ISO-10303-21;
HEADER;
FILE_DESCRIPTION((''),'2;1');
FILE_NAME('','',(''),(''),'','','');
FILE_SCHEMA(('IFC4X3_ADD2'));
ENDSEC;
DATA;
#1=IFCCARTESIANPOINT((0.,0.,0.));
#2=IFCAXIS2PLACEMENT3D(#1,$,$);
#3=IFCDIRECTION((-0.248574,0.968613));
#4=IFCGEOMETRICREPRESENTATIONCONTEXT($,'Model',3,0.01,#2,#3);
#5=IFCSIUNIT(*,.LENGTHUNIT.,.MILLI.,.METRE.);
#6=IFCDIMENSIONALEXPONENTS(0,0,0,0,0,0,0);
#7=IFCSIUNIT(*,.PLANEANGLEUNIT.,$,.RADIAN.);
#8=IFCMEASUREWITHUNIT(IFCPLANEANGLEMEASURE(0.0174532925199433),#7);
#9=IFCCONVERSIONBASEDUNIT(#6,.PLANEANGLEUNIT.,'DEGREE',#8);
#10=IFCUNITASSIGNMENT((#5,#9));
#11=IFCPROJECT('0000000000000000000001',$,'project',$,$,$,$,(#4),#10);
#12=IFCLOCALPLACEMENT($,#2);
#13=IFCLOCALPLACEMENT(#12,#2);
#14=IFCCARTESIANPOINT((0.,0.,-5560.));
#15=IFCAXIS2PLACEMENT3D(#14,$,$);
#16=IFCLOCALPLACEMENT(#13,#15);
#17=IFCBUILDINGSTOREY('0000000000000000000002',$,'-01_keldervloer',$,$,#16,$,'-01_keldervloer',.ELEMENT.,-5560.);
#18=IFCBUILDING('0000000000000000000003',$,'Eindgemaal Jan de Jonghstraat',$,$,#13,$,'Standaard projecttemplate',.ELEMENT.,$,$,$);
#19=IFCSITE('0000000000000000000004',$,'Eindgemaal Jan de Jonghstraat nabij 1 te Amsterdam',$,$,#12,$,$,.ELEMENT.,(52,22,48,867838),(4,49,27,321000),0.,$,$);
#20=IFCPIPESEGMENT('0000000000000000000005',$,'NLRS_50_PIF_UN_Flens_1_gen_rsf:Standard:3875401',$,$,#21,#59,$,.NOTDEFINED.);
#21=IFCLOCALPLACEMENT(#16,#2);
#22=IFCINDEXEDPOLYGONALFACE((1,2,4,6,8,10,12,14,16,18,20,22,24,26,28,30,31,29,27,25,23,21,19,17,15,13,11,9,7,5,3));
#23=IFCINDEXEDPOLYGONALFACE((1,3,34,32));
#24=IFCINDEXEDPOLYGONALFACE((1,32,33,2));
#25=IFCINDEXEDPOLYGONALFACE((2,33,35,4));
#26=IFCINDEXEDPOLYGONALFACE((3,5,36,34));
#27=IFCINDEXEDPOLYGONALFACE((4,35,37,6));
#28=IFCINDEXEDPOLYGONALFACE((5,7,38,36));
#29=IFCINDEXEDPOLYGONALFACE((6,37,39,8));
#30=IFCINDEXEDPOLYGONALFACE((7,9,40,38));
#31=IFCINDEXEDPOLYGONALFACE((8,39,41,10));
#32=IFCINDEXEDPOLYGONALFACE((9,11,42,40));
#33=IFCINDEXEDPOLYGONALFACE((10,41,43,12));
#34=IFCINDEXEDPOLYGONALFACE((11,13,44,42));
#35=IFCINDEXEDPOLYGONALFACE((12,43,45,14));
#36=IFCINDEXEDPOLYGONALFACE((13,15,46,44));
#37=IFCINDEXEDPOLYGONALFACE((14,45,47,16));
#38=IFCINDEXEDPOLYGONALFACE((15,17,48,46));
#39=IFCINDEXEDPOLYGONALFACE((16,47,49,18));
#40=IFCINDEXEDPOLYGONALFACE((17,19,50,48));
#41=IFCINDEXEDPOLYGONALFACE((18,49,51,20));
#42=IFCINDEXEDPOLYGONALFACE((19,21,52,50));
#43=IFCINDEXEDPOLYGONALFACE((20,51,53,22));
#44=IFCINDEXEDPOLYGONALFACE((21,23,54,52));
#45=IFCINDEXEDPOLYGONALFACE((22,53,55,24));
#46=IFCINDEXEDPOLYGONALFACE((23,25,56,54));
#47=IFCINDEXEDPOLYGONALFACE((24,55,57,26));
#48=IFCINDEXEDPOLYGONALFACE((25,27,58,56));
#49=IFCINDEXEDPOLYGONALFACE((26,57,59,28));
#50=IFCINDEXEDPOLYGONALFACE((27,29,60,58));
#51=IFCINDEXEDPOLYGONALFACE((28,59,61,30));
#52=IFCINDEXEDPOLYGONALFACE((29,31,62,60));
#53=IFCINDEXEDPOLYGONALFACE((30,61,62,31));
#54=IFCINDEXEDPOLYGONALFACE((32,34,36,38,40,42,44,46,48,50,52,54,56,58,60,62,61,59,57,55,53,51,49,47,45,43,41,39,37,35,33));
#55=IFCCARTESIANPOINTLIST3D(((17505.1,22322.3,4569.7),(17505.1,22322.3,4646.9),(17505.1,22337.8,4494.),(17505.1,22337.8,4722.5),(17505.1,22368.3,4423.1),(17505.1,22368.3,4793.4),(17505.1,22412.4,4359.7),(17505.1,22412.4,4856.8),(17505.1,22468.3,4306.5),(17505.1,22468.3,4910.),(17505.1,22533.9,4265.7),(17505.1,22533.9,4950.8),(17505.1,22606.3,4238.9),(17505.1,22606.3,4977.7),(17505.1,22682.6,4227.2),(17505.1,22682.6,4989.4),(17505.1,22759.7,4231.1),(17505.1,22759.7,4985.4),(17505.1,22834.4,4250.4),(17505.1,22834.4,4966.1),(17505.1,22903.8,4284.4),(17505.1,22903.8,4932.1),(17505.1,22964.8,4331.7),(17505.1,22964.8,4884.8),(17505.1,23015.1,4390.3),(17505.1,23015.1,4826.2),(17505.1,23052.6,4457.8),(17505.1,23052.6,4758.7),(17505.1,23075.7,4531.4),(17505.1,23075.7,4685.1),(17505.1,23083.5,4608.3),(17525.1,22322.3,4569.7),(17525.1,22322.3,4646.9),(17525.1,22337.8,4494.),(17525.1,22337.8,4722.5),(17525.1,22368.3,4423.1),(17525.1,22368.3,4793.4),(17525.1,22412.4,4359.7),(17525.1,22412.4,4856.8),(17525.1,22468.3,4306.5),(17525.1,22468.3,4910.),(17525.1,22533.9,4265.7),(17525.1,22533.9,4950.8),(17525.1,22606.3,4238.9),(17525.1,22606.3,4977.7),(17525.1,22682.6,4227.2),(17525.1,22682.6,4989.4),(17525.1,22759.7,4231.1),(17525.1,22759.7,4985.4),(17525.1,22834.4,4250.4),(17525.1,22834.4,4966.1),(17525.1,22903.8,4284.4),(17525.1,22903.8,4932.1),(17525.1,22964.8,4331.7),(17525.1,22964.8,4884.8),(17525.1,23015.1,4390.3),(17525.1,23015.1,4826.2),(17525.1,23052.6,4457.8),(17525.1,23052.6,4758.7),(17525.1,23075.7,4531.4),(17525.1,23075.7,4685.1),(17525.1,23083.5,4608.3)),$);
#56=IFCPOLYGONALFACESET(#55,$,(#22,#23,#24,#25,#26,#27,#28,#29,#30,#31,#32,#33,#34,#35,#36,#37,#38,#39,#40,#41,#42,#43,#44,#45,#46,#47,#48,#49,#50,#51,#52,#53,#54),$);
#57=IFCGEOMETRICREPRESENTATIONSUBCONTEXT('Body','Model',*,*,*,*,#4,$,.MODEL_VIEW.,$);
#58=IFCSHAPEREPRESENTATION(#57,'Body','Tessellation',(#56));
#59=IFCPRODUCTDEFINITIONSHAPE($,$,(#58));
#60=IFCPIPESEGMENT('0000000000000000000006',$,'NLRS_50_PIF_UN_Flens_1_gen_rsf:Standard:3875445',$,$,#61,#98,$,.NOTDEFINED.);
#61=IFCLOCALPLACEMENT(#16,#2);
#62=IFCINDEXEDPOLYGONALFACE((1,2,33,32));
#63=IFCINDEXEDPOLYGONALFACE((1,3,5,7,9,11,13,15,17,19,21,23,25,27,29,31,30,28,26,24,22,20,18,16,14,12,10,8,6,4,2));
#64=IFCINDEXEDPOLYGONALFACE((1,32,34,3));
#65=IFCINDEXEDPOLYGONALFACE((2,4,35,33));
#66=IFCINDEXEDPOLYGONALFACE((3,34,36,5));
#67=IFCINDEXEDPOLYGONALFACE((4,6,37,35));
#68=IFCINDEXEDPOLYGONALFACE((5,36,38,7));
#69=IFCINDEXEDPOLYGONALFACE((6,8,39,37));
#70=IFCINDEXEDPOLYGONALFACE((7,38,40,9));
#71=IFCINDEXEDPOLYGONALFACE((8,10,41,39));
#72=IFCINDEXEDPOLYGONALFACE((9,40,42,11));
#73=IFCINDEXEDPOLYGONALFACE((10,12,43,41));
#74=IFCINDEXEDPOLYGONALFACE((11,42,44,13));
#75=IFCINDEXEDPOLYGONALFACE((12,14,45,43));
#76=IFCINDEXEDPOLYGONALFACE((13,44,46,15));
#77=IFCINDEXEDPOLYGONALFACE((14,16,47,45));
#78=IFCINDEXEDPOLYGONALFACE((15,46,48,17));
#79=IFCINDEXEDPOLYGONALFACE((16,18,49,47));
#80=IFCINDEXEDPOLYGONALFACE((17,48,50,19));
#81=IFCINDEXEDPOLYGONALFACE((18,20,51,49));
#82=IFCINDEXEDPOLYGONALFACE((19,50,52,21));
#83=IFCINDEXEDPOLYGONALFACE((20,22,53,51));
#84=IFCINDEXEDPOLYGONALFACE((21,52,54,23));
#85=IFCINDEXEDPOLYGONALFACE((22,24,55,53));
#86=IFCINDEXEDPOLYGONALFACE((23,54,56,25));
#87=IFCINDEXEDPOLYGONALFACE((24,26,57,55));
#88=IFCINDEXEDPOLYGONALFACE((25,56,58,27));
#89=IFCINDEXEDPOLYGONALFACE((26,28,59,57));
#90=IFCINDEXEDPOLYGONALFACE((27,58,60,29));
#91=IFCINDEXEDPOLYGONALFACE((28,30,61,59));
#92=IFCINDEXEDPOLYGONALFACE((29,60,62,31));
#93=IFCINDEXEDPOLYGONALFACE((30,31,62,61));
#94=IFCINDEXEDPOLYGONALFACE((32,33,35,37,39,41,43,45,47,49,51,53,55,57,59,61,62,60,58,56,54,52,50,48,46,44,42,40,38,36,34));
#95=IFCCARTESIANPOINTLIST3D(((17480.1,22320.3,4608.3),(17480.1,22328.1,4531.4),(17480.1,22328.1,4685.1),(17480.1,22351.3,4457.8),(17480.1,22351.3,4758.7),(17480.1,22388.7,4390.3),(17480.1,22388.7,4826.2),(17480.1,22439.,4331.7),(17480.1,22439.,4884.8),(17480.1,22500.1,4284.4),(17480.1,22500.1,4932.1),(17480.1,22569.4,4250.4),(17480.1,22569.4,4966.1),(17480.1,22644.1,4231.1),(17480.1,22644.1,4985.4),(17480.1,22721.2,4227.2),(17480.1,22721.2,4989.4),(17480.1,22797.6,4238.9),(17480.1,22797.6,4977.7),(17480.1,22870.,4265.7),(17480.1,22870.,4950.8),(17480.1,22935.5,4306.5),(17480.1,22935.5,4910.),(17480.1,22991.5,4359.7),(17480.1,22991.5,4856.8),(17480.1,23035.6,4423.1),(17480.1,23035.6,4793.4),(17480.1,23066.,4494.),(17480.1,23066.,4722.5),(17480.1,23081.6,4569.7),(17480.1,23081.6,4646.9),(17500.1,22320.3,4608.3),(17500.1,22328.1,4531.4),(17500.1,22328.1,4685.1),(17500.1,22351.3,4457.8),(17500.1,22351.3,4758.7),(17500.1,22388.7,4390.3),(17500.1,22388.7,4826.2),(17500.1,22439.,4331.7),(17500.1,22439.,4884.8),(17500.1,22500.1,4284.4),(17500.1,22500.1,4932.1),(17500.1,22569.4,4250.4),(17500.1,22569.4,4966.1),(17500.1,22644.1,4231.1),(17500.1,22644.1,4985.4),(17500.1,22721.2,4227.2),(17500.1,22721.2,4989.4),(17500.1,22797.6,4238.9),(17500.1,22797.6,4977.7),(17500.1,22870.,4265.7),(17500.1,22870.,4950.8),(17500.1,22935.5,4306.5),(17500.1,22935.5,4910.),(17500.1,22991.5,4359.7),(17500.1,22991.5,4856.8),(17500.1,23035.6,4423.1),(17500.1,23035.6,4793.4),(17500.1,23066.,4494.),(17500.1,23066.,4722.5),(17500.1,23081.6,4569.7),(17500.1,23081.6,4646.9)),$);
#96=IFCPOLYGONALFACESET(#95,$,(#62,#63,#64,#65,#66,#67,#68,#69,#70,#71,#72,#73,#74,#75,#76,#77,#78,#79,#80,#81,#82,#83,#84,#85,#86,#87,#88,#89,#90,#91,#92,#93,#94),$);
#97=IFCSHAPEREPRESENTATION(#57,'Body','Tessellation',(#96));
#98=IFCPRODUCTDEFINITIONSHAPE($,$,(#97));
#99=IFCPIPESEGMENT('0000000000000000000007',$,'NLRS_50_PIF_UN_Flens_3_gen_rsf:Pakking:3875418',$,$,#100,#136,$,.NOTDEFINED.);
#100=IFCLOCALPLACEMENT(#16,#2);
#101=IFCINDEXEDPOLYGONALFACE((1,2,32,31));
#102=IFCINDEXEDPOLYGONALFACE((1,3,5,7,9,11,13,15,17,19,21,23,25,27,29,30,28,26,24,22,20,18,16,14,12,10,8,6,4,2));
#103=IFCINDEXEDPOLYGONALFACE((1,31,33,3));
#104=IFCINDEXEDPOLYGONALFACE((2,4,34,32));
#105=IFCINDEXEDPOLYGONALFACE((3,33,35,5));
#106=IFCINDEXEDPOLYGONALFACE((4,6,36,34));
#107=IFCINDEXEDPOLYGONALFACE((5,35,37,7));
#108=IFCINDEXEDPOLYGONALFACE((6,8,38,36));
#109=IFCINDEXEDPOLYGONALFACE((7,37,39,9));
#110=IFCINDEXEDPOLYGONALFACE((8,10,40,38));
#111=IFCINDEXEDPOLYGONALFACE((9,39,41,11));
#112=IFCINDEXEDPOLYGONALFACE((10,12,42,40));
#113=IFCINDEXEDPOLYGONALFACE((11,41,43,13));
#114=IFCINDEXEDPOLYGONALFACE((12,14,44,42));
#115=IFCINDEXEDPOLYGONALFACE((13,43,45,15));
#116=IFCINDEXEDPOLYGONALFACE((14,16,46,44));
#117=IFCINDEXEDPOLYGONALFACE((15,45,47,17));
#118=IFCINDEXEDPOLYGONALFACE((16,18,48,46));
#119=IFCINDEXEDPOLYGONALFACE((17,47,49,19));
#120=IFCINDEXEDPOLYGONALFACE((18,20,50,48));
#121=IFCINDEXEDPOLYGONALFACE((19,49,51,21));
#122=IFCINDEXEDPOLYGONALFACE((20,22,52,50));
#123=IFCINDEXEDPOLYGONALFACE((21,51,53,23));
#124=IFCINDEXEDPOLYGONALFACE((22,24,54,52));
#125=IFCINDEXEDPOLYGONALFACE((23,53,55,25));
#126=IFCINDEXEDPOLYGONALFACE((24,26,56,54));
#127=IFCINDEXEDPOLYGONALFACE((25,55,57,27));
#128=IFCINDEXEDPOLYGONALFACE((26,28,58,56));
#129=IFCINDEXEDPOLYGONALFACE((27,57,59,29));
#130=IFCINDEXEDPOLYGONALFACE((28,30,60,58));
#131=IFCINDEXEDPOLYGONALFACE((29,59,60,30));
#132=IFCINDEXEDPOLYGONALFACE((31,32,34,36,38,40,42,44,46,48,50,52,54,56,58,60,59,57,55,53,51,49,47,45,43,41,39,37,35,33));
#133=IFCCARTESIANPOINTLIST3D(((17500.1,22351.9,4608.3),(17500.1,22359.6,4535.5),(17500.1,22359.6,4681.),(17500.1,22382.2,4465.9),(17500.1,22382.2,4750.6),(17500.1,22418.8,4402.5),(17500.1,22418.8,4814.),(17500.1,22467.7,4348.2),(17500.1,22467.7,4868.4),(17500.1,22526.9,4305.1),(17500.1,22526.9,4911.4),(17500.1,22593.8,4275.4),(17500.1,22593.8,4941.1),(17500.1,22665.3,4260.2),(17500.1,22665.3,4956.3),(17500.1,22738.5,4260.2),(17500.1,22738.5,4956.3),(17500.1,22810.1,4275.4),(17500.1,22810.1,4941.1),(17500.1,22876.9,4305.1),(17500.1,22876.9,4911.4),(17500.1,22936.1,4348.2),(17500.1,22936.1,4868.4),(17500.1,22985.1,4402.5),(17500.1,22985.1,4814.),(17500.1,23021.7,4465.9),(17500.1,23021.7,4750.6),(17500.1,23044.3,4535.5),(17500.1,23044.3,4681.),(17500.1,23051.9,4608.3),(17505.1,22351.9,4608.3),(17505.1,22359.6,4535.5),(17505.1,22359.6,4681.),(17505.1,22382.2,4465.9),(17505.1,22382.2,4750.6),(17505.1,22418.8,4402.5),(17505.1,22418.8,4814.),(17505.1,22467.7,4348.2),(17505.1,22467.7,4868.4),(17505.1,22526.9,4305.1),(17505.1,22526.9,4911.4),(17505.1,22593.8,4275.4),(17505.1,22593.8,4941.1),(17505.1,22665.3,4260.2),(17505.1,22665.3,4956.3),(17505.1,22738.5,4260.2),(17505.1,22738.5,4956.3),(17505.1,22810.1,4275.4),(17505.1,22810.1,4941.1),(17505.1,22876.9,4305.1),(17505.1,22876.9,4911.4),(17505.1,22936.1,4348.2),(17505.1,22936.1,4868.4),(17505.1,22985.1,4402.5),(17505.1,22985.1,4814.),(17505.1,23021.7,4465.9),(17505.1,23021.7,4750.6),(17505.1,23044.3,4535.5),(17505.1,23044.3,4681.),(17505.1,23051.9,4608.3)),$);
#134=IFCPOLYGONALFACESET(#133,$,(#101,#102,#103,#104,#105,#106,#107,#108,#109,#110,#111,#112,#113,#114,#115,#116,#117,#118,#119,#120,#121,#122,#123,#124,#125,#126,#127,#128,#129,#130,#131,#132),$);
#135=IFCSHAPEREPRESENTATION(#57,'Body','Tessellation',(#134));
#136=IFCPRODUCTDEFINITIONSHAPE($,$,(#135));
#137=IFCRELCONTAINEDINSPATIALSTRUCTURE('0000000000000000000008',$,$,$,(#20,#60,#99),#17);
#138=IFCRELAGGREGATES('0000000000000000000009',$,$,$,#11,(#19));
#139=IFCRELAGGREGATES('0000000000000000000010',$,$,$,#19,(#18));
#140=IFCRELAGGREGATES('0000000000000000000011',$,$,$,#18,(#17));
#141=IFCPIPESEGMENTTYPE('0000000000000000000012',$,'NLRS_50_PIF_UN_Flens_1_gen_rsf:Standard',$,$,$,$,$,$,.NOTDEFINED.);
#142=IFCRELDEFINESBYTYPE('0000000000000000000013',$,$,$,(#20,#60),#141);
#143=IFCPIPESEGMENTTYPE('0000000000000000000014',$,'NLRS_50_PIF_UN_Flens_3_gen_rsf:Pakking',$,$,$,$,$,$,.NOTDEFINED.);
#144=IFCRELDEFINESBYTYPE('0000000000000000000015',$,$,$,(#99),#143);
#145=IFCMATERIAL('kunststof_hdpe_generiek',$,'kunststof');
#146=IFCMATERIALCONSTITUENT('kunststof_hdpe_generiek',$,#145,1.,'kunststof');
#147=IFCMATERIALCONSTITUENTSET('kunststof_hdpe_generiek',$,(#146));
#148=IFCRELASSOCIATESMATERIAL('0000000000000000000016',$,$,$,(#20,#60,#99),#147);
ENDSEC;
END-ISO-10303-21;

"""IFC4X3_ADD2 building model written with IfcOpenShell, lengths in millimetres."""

from ifc_helpers import new_model, entity, si_unit, converted_unit, direction, frame, frame_2d, origin, place, context, subcontext, project, spatial, circle, extrude, source, transform, mapped, material, constituent, constituent_set, type_object, type_shapes, element, save


model = new_model("IFC4X3_ADD2")

# Units and contexts
model_context = context("Model", 3, precision=0.01, world=origin(), true_north=direction((-0.248574, 0.968613)))
body_context = subcontext(model_context, "Body", "Model", "MODEL_VIEW")
ifc_project = project(units=[si_unit("LENGTHUNIT", "METRE", prefix="MILLI"), converted_unit("PLANEANGLEUNIT", "DEGREE", entity("IfcPlaneAngleMeasure", 0.0174532925199433), si_unit("PLANEANGLEUNIT", "RADIAN"), dimensions=[0, 0, 0, 0, 0, 0, 0])], contexts=[model_context])

# Site, building, storey
site_placement = place(None, origin())
site = spatial("IfcSite", under=ifc_project, at=site_placement, Name="Eindgemaal Jan de Jonghstraat nabij 1 te Amsterdam", CompositionType="ELEMENT", RefLatitude=(52, 22, 48, 867838), RefLongitude=(4, 49, 27, 321000), RefElevation=0.0)
building_placement = place(site_placement, origin())
building = spatial("IfcBuilding", under=site, at=building_placement, Name="Eindgemaal Jan de Jonghstraat", LongName="Standaard projecttemplate", CompositionType="ELEMENT")
storey_placement = place(building_placement, frame((0.0, 0.0, -5560.0)))
storey = spatial("IfcBuildingStorey", under=building, at=storey_placement, Name="-01_keldervloer", LongName="-01_keldervloer", CompositionType="ELEMENT", Elevation=-5560.0)

# Pipe segments
ifc_material_1 = material(Name="kunststof_hdpe_generiek", Category="kunststof")
ifc_constituent_1 = constituent(ifc_material_1, Name="kunststof_hdpe_generiek", Category="kunststof", fraction=1.0)
ifc_constituent_set_1 = constituent_set(constituents=[ifc_constituent_1], Name="kunststof_hdpe_generiek")
pipe_segment_type_1 = type_object("IfcPipeSegmentType", Name="NLRS_50_PIF_UN_Flens_1_gen_rsf:Standard", PredefinedType="NOTDEFINED")
shared_shape_1 = source(origin(), body_context, "Body", "SweptSolid", [
    extrude(circle(Radius=381.6, at=frame_2d((0.0, 0.0), x_axis=(1.0, 0.0))), frame((-10.0, 0.0, 0.0), z_axis=(1.0, 0.0, 0.0), x_axis=(0.0, 1.0, 0.0)), (0.0, 0.0, 1.0), 20.0),
])
type_shapes(pipe_segment_type_1, [shared_shape_1])
pipe_segment_1_placement = place(storey_placement, frame((17515.1, 22701.9, 4608.3)))
element("IfcPipeSegment", 1, at=pipe_segment_1_placement, inside=storey, type_object=pipe_segment_type_1, material=ifc_constituent_set_1, Name="NLRS_50_PIF_UN_Flens_1_gen_rsf:Standard:3875401", PredefinedType="NOTDEFINED", context=body_context, shape_type="MappedRepresentation", body=[
    mapped(shared_shape_1, transform((0.0, 0.0, 0.0), scale=1.0)),
])
pipe_segment_2_placement = place(storey_placement, frame((17490.1, 22701.9, 4608.3), z_axis=(0.0, 0.0, 1.0), x_axis=(-1.0, 0.0, 0.0)))
element("IfcPipeSegment", 2, at=pipe_segment_2_placement, inside=storey, type_object=pipe_segment_type_1, material=ifc_constituent_set_1, Name="NLRS_50_PIF_UN_Flens_1_gen_rsf:Standard:3875445", PredefinedType="NOTDEFINED", context=body_context, shape_type="MappedRepresentation", body=[
    mapped(shared_shape_1, transform((0.0, 0.0, 0.0), scale=1.0)),
])
pipe_segment_type_2 = type_object("IfcPipeSegmentType", Name="NLRS_50_PIF_UN_Flens_3_gen_rsf:Pakking", PredefinedType="NOTDEFINED")
shared_shape_2 = source(origin(), body_context, "Body", "SweptSolid", [
    extrude(circle(Radius=350.0, at=frame_2d((0.0, 0.0), x_axis=(1.0, 0.0))), frame((0.0, 0.0, 0.0), z_axis=(0.0, 0.0, 1.0), x_axis=(0.0, -1.0, 0.0)), (0.0, 0.0, 1.0), 5.0),
])
type_shapes(pipe_segment_type_2, [shared_shape_2])
pipe_segment_3_placement = place(storey_placement, frame((17500.1, 22701.9, 4608.3), z_axis=(1.0, 0.0, 0.0), x_axis=(0.0, 0.0, 1.0)))
element("IfcPipeSegment", 3, at=pipe_segment_3_placement, inside=storey, type_object=pipe_segment_type_2, material=ifc_constituent_set_1, Name="NLRS_50_PIF_UN_Flens_3_gen_rsf:Pakking:3875418", PredefinedType="NOTDEFINED", context=body_context, shape_type="MappedRepresentation", body=[
    mapped(shared_shape_2, transform((0.0, 0.0, 0.0), scale=1.0)),
])

save(model, "model.ifc")
